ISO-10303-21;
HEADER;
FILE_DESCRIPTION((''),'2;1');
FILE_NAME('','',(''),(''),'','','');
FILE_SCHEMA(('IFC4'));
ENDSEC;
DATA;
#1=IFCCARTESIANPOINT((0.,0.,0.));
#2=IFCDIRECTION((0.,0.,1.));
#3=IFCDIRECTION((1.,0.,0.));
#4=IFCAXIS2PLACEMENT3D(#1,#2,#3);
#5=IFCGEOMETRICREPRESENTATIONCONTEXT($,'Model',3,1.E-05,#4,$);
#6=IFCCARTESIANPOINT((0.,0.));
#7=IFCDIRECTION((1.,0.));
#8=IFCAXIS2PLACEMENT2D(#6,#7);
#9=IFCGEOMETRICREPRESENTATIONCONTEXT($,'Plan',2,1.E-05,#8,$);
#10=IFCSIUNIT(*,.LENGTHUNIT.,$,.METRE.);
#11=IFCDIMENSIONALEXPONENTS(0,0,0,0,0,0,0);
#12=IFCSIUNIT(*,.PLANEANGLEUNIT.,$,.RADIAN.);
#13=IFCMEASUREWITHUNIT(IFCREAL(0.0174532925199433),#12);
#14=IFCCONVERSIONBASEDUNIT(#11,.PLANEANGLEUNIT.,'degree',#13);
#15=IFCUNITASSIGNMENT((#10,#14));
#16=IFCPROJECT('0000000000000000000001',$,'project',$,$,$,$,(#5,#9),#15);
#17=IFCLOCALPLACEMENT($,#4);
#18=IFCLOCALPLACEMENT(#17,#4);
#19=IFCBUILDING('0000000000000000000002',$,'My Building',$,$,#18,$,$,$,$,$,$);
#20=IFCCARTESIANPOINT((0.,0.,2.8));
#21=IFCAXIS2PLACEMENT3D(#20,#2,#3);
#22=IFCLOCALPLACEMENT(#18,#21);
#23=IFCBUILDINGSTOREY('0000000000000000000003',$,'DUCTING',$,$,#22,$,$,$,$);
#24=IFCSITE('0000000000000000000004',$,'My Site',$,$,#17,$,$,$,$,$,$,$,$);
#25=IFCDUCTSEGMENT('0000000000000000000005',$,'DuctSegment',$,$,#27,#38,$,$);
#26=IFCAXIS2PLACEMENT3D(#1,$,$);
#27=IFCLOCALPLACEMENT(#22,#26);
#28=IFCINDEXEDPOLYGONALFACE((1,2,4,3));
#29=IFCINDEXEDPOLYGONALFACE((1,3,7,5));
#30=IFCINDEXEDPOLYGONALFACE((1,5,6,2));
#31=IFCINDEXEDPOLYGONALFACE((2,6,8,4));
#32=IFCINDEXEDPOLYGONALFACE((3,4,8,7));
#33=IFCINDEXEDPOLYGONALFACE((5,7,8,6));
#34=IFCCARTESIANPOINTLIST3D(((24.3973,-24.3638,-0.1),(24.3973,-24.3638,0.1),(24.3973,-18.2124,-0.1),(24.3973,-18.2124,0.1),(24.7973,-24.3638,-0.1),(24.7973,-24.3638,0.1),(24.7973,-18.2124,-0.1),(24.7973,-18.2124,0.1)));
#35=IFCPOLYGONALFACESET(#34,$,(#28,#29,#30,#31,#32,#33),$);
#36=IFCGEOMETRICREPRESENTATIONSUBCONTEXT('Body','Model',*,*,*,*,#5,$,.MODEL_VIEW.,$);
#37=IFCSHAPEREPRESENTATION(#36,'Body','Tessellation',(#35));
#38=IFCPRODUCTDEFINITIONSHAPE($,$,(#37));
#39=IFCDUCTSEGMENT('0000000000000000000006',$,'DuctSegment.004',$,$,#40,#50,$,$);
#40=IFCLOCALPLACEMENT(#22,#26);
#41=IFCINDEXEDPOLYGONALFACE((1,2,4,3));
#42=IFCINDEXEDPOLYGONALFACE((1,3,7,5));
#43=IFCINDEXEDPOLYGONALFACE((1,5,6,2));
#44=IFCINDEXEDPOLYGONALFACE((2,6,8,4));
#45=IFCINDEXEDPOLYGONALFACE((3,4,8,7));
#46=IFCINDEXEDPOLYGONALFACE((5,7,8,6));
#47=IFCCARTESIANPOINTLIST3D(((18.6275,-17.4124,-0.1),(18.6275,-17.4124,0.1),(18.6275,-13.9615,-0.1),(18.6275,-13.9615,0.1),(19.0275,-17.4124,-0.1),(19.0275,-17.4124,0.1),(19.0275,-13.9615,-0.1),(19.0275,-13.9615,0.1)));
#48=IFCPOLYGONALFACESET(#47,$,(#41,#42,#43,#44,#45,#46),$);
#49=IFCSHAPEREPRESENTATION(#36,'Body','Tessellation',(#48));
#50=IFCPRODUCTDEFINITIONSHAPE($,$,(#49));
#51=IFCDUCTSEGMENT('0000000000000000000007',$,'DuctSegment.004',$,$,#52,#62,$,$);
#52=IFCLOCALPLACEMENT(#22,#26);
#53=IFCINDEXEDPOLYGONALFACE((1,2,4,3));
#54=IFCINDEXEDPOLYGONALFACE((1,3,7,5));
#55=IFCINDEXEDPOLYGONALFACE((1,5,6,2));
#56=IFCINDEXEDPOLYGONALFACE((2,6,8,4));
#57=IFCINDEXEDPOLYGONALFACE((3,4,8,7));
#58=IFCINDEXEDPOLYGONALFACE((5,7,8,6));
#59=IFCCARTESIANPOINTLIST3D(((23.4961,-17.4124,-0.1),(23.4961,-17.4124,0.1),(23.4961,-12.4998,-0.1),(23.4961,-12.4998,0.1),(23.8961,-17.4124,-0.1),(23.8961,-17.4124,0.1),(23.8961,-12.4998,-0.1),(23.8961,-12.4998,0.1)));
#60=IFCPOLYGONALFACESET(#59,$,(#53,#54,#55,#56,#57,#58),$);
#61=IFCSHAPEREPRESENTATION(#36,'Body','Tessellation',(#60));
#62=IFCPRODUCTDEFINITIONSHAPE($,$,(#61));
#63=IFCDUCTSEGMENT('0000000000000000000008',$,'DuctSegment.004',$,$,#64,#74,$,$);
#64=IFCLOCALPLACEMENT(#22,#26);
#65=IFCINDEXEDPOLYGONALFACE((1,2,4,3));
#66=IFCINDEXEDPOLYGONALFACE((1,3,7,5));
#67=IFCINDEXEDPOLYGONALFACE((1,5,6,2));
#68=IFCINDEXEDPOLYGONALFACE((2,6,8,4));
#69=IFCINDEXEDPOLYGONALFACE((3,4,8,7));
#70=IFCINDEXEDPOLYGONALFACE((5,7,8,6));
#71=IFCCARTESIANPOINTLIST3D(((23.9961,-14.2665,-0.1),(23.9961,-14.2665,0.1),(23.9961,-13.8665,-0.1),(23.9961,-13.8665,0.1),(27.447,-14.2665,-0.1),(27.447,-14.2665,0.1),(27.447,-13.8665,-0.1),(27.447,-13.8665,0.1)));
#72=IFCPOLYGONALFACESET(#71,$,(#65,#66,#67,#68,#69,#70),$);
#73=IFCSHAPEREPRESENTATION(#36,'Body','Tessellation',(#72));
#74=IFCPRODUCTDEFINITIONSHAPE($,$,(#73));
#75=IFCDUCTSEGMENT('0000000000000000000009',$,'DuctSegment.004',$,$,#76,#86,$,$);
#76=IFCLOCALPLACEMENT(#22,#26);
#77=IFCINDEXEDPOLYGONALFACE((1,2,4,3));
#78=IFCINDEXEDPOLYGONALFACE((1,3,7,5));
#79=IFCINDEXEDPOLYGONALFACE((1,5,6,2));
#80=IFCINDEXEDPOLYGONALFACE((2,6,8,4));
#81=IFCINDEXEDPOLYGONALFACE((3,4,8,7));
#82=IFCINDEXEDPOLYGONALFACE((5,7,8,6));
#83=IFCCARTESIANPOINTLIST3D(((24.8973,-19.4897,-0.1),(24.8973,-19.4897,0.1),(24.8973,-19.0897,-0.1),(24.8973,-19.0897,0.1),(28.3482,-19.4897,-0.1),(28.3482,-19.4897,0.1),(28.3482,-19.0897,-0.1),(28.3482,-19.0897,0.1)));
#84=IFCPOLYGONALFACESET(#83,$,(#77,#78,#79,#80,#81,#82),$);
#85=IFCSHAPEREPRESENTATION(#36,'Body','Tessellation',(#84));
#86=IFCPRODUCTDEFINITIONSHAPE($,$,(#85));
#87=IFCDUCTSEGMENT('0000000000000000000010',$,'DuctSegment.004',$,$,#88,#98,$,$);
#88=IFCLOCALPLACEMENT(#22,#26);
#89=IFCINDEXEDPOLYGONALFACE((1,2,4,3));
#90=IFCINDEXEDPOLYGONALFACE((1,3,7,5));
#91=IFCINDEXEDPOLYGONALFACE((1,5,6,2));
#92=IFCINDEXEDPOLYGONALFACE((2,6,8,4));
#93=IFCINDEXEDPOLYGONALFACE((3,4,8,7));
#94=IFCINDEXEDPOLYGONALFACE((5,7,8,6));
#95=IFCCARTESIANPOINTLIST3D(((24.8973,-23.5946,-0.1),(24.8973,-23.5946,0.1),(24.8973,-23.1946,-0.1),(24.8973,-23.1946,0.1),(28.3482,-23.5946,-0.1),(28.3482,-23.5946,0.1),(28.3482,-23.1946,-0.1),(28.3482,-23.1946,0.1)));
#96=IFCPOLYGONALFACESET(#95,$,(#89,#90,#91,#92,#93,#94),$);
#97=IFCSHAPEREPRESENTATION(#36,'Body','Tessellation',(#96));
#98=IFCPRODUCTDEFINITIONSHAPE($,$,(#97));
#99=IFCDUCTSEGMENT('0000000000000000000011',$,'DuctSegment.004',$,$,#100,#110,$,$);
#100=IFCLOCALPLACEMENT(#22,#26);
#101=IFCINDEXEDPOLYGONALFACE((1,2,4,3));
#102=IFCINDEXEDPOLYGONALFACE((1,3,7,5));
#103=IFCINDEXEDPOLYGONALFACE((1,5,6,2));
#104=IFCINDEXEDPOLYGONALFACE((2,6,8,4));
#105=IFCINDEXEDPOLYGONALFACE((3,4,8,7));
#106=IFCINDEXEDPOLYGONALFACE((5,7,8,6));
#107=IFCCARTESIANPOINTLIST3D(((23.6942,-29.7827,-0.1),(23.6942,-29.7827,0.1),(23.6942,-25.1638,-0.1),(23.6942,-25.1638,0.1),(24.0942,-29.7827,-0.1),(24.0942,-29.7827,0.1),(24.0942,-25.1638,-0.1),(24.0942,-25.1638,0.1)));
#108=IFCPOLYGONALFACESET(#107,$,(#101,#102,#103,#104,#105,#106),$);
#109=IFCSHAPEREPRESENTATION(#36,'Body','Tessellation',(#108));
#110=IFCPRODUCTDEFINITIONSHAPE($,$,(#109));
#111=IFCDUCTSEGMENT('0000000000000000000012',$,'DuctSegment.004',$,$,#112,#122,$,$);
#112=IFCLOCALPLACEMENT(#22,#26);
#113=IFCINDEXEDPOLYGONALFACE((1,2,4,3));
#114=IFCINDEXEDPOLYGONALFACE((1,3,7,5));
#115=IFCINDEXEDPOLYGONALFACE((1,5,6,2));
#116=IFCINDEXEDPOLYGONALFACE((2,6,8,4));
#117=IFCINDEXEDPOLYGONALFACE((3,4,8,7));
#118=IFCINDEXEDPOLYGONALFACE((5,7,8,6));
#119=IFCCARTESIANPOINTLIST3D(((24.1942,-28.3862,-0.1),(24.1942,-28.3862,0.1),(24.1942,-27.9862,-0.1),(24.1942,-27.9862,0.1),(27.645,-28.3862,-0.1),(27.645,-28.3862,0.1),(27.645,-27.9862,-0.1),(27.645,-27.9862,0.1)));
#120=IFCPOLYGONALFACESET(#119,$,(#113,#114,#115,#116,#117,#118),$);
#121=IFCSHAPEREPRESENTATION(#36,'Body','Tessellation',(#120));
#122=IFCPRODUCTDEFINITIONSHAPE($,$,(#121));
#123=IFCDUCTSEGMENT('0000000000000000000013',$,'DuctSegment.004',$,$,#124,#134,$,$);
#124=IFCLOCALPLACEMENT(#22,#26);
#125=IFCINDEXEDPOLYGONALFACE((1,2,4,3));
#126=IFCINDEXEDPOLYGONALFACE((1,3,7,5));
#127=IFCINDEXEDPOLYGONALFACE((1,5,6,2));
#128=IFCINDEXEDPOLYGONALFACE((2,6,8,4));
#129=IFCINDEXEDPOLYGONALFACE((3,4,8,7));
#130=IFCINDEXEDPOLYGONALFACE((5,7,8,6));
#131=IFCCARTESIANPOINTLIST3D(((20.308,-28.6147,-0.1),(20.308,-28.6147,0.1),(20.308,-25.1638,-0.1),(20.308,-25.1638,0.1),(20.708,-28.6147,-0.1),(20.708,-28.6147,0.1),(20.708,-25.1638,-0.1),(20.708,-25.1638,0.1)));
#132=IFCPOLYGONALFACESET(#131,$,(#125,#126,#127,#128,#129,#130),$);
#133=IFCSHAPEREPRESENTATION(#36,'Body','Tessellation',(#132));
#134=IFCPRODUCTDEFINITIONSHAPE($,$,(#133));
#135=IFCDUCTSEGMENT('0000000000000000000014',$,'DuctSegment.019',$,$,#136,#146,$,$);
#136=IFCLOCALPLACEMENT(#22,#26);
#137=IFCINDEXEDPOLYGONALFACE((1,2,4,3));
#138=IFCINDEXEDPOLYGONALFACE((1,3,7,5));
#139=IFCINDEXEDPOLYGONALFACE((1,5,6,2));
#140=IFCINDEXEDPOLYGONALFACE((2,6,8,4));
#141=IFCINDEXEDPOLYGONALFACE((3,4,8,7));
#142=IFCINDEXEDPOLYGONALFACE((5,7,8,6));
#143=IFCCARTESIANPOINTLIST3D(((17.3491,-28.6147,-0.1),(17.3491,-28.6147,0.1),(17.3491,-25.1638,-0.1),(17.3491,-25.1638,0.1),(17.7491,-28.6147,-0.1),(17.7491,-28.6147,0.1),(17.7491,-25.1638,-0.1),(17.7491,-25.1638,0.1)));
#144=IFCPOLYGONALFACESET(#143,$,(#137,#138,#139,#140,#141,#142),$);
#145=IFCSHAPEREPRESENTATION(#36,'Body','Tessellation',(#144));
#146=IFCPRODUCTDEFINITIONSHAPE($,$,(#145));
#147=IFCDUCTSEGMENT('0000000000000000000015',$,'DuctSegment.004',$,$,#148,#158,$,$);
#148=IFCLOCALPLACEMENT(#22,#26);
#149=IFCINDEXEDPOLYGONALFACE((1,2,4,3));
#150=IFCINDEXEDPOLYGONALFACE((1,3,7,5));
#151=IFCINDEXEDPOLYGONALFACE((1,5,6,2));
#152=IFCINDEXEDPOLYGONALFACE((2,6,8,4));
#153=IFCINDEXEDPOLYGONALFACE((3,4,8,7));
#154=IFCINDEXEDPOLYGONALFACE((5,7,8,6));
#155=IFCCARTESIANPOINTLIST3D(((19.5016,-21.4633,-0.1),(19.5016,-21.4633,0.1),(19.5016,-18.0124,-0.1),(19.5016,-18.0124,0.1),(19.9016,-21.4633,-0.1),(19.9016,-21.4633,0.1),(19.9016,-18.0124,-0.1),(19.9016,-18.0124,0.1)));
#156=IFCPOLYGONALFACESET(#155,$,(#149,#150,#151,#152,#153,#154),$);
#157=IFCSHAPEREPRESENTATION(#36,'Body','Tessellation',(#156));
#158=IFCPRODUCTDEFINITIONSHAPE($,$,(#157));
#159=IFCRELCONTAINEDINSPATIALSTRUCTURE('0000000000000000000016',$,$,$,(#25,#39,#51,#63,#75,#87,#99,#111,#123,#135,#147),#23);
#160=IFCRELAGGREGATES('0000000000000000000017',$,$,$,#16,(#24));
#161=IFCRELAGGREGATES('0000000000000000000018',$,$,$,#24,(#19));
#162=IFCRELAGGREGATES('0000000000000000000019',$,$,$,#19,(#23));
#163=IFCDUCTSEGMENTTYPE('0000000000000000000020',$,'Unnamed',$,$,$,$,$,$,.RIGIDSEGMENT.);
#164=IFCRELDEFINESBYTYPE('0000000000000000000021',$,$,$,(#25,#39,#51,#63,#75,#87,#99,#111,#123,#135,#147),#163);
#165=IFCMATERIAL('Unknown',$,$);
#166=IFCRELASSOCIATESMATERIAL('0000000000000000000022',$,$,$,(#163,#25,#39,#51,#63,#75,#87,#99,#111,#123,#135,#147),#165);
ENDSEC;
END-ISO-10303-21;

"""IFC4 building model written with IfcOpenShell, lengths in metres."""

from ifc_helpers import new_model, entity, si_unit, converted_unit, frame, origin_with_axes, origin_2d_with_axis, place, context, subcontext, project, spatial, rectangle, extrude, material, material_profile, profile_set, profile_usage, type_object, element, save


model = new_model("IFC4")

# Units and contexts
model_context = context("Model", 3, precision=1e-05, world=origin_with_axes())
plan_context = context("Plan", 2, precision=1e-05, world=origin_2d_with_axis())
body_context = subcontext(model_context, "Body", "Model", "MODEL_VIEW")
ifc_project = project(units=[si_unit("LENGTHUNIT", "METRE"), converted_unit("PLANEANGLEUNIT", "degree", entity("IfcReal", 0.0174532925199433), si_unit("PLANEANGLEUNIT", "RADIAN"), dimensions=[0, 0, 0, 0, 0, 0, 0])], contexts=[model_context, plan_context])

# Site, building, storey
site_placement = place(None, origin_with_axes())
site = spatial("IfcSite", under=ifc_project, at=site_placement, Name="My Site")
building_placement = place(site_placement, origin_with_axes())
building = spatial("IfcBuilding", under=site, at=building_placement, Name="My Building")
storey_placement = place(building_placement, frame((0.0, 0.0, 2.8), z_axis=(0.0, 0.0, 1.0), x_axis=(1.0, 0.0, 0.0)))
storey = spatial("IfcBuildingStorey", under=building, at=storey_placement, Name="DUCTING")

# Duct segments
ifc_material = material(Name="Unknown")
ifc_material_profile_1 = material_profile(ifc_material, rectangle(XDim=0.4, YDim=0.2))
ifc_profile_set_1 = profile_set([ifc_material_profile_1])
ifc_profile_usage_1 = profile_usage(ifc_profile_set_1, cardinal=5)
duct_segment_type = type_object("IfcDuctSegmentType", Name="Unnamed", PredefinedType="RIGIDSEGMENT", material=ifc_profile_set_1)
duct_segment_1_placement = place(storey_placement, frame((24.5973, -18.2124, 0.0), z_axis=(0.0, -1.0, 0.0), x_axis=(1.0, 0.0, 0.0)))
element("IfcDuctSegment", 1, at=duct_segment_1_placement, inside=storey, type_object=duct_segment_type, material=ifc_profile_usage_1, Name="DuctSegment", context=body_context, shape_type="SweptSolid", body=[
    extrude(rectangle(XDim=0.4, YDim=0.2), origin_with_axes(), (0.0, 0.0, 1.0), 6.1514),
])
ifc_profile_usage_2 = profile_usage(ifc_profile_set_1, cardinal=5)
duct_segment_2_placement = place(storey_placement, frame((18.8275, -17.4124, 0.0), z_axis=(0.0, 1.0, 0.0), x_axis=(-1.0, 0.0, 0.0)))
element("IfcDuctSegment", 2, at=duct_segment_2_placement, inside=storey, type_object=duct_segment_type, material=ifc_profile_usage_2, Name="DuctSegment.004", context=body_context, shape_type="SweptSolid", body=[
    extrude(rectangle(XDim=0.4, YDim=0.2), origin_with_axes(), (0.0, 0.0, 1.0), 3.4509),
])
ifc_profile_usage_3 = profile_usage(ifc_profile_set_1, cardinal=5)
duct_segment_3_placement = place(storey_placement, frame((23.6961, -17.4124, 0.0), z_axis=(0.0, 1.0, 0.0), x_axis=(-1.0, 0.0, 0.0)))
element("IfcDuctSegment", 3, at=duct_segment_3_placement, inside=storey, type_object=duct_segment_type, material=ifc_profile_usage_3, Name="DuctSegment.004", context=body_context, shape_type="SweptSolid", body=[
    extrude(rectangle(XDim=0.4, YDim=0.2), origin_with_axes(), (0.0, 0.0, 1.0), 4.9125),
])
ifc_profile_usage_4 = profile_usage(ifc_profile_set_1, cardinal=5)
duct_segment_4_placement = place(storey_placement, frame((23.9961, -14.0665, 0.0), z_axis=(1.0, 0.0, 0.0), x_axis=(0.0, 1.0, 0.0)))
element("IfcDuctSegment", 4, at=duct_segment_4_placement, inside=storey, type_object=duct_segment_type, material=ifc_profile_usage_4, Name="DuctSegment.004", context=body_context, shape_type="SweptSolid", body=[
    extrude(rectangle(XDim=0.4, YDim=0.2), origin_with_axes(), (0.0, 0.0, 1.0), 3.4509),
])
ifc_profile_usage_5 = profile_usage(ifc_profile_set_1, cardinal=5)
duct_segment_5_placement = place(storey_placement, frame((24.8973, -19.2897, 0.0), z_axis=(1.0, 0.0, 0.0), x_axis=(0.0, 1.0, 0.0)))
element("IfcDuctSegment", 5, at=duct_segment_5_placement, inside=storey, type_object=duct_segment_type, material=ifc_profile_usage_5, Name="DuctSegment.004", context=body_context, shape_type="SweptSolid", body=[
    extrude(rectangle(XDim=0.4, YDim=0.2), origin_with_axes(), (0.0, 0.0, 1.0), 3.4509),
])
ifc_profile_usage_6 = profile_usage(ifc_profile_set_1, cardinal=5)
duct_segment_6_placement = place(storey_placement, frame((24.8973, -23.3946, 0.0), z_axis=(1.0, 0.0, 0.0), x_axis=(0.0, 1.0, 0.0)))
element("IfcDuctSegment", 6, at=duct_segment_6_placement, inside=storey, type_object=duct_segment_type, material=ifc_profile_usage_6, Name="DuctSegment.004", context=body_context, shape_type="SweptSolid", body=[
    extrude(rectangle(XDim=0.4, YDim=0.2), origin_with_axes(), (0.0, 0.0, 1.0), 3.4509),
])
ifc_profile_usage_7 = profile_usage(ifc_profile_set_1, cardinal=5)
duct_segment_7_placement = place(storey_placement, frame((23.8942, -25.1638, 0.0), z_axis=(0.0, -1.0, 0.0), x_axis=(1.0, 0.0, 0.0)))
element("IfcDuctSegment", 7, at=duct_segment_7_placement, inside=storey, type_object=duct_segment_type, material=ifc_profile_usage_7, Name="DuctSegment.004", context=body_context, shape_type="SweptSolid", body=[
    extrude(rectangle(XDim=0.4, YDim=0.2), origin_with_axes(), (0.0, 0.0, 1.0), 4.619),
])
ifc_profile_usage_8 = profile_usage(ifc_profile_set_1, cardinal=5)
duct_segment_8_placement = place(storey_placement, frame((24.1942, -28.1862, 0.0), z_axis=(1.0, 0.0, 0.0), x_axis=(0.0, 1.0, 0.0)))
element("IfcDuctSegment", 8, at=duct_segment_8_placement, inside=storey, type_object=duct_segment_type, material=ifc_profile_usage_8, Name="DuctSegment.004", context=body_context, shape_type="SweptSolid", body=[
    extrude(rectangle(XDim=0.4, YDim=0.2), origin_with_axes(), (0.0, 0.0, 1.0), 3.4509),
])
ifc_profile_usage_9 = profile_usage(ifc_profile_set_1, cardinal=5)
duct_segment_9_placement = place(storey_placement, frame((20.508, -25.1638, 0.0), z_axis=(0.0, -1.0, 0.0), x_axis=(1.0, 0.0, 0.0)))
element("IfcDuctSegment", 9, at=duct_segment_9_placement, inside=storey, type_object=duct_segment_type, material=ifc_profile_usage_9, Name="DuctSegment.004", context=body_context, shape_type="SweptSolid", body=[
    extrude(rectangle(XDim=0.4, YDim=0.2), origin_with_axes(), (0.0, 0.0, 1.0), 3.4509),
])
ifc_profile_usage_10 = profile_usage(ifc_profile_set_1, cardinal=5)
duct_segment_10_placement = place(storey_placement, frame((17.5491, -25.1638, 0.0), z_axis=(0.0, -1.0, 0.0), x_axis=(1.0, 0.0, 0.0)))
element("IfcDuctSegment", 10, at=duct_segment_10_placement, inside=storey, type_object=duct_segment_type, material=ifc_profile_usage_10, Name="DuctSegment.019", context=body_context, shape_type="SweptSolid", body=[
    extrude(rectangle(XDim=0.4, YDim=0.2), origin_with_axes(), (0.0, 0.0, 1.0), 3.4509),
])
ifc_profile_usage_11 = profile_usage(ifc_profile_set_1, cardinal=5)
duct_segment_11_placement = place(storey_placement, frame((19.7016, -18.0124, 0.0), z_axis=(0.0, -1.0, 0.0), x_axis=(1.0, 0.0, 0.0)))
element("IfcDuctSegment", 11, at=duct_segment_11_placement, inside=storey, type_object=duct_segment_type, material=ifc_profile_usage_11, Name="DuctSegment.004", context=body_context, shape_type="SweptSolid", body=[
    extrude(rectangle(XDim=0.4, YDim=0.2), origin_with_axes(), (0.0, 0.0, 1.0), 3.4509),
])

save(model, "model.ifc")
